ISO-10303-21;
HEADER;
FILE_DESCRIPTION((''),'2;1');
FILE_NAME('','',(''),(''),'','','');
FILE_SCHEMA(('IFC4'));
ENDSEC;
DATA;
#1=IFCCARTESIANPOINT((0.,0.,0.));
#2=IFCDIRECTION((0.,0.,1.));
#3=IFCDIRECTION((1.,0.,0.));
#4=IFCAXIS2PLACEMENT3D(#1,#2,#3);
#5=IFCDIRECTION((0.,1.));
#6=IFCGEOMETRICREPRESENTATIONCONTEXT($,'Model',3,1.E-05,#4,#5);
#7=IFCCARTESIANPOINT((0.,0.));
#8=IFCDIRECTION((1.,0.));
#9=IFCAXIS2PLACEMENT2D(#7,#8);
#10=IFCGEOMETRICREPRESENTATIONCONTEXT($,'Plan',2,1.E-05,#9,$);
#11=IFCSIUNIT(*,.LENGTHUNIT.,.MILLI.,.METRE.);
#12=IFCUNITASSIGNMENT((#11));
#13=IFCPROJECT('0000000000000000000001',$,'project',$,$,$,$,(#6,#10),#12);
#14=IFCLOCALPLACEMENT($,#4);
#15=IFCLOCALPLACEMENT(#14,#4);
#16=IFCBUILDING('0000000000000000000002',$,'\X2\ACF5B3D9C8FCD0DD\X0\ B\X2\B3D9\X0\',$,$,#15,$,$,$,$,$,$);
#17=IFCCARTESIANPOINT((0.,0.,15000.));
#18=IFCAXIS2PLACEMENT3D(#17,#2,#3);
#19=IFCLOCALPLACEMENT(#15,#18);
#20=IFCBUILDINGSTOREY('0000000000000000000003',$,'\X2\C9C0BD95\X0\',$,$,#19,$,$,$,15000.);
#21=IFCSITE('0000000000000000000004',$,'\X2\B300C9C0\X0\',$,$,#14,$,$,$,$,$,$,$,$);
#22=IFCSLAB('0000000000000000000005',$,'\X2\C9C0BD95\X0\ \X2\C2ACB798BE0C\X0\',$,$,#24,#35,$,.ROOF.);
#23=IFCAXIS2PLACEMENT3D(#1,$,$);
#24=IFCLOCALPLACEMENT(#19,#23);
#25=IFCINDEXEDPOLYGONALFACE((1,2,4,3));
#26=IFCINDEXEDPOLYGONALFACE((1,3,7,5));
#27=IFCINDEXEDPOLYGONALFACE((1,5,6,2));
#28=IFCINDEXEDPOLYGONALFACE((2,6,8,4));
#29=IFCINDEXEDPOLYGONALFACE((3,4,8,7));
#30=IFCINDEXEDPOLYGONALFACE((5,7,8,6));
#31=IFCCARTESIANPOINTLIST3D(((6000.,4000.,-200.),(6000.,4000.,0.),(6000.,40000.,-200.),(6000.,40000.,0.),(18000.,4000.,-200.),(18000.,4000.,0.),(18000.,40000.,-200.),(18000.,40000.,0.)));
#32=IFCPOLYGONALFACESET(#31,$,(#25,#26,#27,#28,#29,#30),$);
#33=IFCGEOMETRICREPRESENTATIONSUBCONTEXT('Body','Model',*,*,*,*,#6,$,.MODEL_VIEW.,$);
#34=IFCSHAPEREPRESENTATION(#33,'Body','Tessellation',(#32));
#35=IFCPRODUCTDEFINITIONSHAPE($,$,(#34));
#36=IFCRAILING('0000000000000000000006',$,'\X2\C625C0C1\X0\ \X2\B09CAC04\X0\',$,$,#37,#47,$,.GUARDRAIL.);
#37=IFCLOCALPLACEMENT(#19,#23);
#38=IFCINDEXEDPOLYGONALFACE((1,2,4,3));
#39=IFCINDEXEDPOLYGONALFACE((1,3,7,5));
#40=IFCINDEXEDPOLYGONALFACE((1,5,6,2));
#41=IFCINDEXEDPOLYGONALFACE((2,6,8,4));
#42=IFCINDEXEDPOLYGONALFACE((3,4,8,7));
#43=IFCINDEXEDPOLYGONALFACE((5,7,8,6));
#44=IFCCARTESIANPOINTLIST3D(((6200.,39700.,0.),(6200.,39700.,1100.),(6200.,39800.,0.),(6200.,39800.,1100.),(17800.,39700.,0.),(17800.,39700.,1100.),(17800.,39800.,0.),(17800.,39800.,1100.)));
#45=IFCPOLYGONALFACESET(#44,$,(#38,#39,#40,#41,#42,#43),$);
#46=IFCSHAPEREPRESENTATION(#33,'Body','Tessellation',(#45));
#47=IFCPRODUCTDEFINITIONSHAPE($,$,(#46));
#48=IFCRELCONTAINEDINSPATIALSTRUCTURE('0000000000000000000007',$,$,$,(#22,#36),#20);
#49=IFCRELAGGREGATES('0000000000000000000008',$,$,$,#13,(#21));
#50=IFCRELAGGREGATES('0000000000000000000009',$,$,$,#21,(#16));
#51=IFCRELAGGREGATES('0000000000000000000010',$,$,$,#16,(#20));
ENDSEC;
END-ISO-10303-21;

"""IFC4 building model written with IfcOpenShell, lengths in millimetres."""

from ifc_helpers import new_model, si_unit, direction, frame, origin_with_axes, origin_2d_with_axis, place, context, subcontext, project, spatial, polyline, outline, extrude, element, save


model = new_model("IFC4")

# Units and contexts
model_context = context("Model", 3, precision=1e-05, world=origin_with_axes(), true_north=direction((0.0, 1.0)))
plan_context = context("Plan", 2, precision=1e-05, world=origin_2d_with_axis())
body_context = subcontext(model_context, "Body", "Model", "MODEL_VIEW")
ifc_project = project(units=[si_unit("LENGTHUNIT", "METRE", prefix="MILLI")], contexts=[model_context, plan_context])

# Site, building, storey
site_placement = place(None, origin_with_axes())
site = spatial("IfcSite", under=ifc_project, at=site_placement, Name="대지")
building_placement = place(site_placement, origin_with_axes())
building = spatial("IfcBuilding", under=site, at=building_placement, Name="공동주택 B동")
storey_placement = place(building_placement, frame((0.0, 0.0, 15000.0), z_axis=(0.0, 0.0, 1.0), x_axis=(1.0, 0.0, 0.0)))
storey = spatial("IfcBuildingStorey", under=building, at=storey_placement, Name="지붕", Elevation=15000.0)

# Slab
slab_placement = place(storey_placement, origin_with_axes())
element("IfcSlab", 1, at=slab_placement, inside=storey, Name="지붕 슬래브", PredefinedType="ROOF", context=body_context, shape_type="SweptSolid", body=[
    extrude(outline(polyline([(6000.0, 4000.0), (18000.0, 4000.0), (18000.0, 40000.0), (6000.0, 40000.0), (6000.0, 4000.0)])), frame((0.0, 0.0, -200.0), z_axis=(0.0, 0.0, 1.0), x_axis=(1.0, 0.0, 0.0)), (0.0, 0.0, 1.0), 200.0),
])

# Railing
railing_placement = place(storey_placement, origin_with_axes())
element("IfcRailing", 2, at=railing_placement, inside=storey, Name="옥상 난간", PredefinedType="GUARDRAIL", context=body_context, shape_type="SweptSolid", body=[
    extrude(outline(polyline([(6200.0, 39700.0), (17800.0, 39700.0), (17800.0, 39800.0), (6200.0, 39800.0), (6200.0, 39700.0)])), origin_with_axes(), (0.0, 0.0, 1.0), 1100.0),
])

save(model, "model.ifc")
